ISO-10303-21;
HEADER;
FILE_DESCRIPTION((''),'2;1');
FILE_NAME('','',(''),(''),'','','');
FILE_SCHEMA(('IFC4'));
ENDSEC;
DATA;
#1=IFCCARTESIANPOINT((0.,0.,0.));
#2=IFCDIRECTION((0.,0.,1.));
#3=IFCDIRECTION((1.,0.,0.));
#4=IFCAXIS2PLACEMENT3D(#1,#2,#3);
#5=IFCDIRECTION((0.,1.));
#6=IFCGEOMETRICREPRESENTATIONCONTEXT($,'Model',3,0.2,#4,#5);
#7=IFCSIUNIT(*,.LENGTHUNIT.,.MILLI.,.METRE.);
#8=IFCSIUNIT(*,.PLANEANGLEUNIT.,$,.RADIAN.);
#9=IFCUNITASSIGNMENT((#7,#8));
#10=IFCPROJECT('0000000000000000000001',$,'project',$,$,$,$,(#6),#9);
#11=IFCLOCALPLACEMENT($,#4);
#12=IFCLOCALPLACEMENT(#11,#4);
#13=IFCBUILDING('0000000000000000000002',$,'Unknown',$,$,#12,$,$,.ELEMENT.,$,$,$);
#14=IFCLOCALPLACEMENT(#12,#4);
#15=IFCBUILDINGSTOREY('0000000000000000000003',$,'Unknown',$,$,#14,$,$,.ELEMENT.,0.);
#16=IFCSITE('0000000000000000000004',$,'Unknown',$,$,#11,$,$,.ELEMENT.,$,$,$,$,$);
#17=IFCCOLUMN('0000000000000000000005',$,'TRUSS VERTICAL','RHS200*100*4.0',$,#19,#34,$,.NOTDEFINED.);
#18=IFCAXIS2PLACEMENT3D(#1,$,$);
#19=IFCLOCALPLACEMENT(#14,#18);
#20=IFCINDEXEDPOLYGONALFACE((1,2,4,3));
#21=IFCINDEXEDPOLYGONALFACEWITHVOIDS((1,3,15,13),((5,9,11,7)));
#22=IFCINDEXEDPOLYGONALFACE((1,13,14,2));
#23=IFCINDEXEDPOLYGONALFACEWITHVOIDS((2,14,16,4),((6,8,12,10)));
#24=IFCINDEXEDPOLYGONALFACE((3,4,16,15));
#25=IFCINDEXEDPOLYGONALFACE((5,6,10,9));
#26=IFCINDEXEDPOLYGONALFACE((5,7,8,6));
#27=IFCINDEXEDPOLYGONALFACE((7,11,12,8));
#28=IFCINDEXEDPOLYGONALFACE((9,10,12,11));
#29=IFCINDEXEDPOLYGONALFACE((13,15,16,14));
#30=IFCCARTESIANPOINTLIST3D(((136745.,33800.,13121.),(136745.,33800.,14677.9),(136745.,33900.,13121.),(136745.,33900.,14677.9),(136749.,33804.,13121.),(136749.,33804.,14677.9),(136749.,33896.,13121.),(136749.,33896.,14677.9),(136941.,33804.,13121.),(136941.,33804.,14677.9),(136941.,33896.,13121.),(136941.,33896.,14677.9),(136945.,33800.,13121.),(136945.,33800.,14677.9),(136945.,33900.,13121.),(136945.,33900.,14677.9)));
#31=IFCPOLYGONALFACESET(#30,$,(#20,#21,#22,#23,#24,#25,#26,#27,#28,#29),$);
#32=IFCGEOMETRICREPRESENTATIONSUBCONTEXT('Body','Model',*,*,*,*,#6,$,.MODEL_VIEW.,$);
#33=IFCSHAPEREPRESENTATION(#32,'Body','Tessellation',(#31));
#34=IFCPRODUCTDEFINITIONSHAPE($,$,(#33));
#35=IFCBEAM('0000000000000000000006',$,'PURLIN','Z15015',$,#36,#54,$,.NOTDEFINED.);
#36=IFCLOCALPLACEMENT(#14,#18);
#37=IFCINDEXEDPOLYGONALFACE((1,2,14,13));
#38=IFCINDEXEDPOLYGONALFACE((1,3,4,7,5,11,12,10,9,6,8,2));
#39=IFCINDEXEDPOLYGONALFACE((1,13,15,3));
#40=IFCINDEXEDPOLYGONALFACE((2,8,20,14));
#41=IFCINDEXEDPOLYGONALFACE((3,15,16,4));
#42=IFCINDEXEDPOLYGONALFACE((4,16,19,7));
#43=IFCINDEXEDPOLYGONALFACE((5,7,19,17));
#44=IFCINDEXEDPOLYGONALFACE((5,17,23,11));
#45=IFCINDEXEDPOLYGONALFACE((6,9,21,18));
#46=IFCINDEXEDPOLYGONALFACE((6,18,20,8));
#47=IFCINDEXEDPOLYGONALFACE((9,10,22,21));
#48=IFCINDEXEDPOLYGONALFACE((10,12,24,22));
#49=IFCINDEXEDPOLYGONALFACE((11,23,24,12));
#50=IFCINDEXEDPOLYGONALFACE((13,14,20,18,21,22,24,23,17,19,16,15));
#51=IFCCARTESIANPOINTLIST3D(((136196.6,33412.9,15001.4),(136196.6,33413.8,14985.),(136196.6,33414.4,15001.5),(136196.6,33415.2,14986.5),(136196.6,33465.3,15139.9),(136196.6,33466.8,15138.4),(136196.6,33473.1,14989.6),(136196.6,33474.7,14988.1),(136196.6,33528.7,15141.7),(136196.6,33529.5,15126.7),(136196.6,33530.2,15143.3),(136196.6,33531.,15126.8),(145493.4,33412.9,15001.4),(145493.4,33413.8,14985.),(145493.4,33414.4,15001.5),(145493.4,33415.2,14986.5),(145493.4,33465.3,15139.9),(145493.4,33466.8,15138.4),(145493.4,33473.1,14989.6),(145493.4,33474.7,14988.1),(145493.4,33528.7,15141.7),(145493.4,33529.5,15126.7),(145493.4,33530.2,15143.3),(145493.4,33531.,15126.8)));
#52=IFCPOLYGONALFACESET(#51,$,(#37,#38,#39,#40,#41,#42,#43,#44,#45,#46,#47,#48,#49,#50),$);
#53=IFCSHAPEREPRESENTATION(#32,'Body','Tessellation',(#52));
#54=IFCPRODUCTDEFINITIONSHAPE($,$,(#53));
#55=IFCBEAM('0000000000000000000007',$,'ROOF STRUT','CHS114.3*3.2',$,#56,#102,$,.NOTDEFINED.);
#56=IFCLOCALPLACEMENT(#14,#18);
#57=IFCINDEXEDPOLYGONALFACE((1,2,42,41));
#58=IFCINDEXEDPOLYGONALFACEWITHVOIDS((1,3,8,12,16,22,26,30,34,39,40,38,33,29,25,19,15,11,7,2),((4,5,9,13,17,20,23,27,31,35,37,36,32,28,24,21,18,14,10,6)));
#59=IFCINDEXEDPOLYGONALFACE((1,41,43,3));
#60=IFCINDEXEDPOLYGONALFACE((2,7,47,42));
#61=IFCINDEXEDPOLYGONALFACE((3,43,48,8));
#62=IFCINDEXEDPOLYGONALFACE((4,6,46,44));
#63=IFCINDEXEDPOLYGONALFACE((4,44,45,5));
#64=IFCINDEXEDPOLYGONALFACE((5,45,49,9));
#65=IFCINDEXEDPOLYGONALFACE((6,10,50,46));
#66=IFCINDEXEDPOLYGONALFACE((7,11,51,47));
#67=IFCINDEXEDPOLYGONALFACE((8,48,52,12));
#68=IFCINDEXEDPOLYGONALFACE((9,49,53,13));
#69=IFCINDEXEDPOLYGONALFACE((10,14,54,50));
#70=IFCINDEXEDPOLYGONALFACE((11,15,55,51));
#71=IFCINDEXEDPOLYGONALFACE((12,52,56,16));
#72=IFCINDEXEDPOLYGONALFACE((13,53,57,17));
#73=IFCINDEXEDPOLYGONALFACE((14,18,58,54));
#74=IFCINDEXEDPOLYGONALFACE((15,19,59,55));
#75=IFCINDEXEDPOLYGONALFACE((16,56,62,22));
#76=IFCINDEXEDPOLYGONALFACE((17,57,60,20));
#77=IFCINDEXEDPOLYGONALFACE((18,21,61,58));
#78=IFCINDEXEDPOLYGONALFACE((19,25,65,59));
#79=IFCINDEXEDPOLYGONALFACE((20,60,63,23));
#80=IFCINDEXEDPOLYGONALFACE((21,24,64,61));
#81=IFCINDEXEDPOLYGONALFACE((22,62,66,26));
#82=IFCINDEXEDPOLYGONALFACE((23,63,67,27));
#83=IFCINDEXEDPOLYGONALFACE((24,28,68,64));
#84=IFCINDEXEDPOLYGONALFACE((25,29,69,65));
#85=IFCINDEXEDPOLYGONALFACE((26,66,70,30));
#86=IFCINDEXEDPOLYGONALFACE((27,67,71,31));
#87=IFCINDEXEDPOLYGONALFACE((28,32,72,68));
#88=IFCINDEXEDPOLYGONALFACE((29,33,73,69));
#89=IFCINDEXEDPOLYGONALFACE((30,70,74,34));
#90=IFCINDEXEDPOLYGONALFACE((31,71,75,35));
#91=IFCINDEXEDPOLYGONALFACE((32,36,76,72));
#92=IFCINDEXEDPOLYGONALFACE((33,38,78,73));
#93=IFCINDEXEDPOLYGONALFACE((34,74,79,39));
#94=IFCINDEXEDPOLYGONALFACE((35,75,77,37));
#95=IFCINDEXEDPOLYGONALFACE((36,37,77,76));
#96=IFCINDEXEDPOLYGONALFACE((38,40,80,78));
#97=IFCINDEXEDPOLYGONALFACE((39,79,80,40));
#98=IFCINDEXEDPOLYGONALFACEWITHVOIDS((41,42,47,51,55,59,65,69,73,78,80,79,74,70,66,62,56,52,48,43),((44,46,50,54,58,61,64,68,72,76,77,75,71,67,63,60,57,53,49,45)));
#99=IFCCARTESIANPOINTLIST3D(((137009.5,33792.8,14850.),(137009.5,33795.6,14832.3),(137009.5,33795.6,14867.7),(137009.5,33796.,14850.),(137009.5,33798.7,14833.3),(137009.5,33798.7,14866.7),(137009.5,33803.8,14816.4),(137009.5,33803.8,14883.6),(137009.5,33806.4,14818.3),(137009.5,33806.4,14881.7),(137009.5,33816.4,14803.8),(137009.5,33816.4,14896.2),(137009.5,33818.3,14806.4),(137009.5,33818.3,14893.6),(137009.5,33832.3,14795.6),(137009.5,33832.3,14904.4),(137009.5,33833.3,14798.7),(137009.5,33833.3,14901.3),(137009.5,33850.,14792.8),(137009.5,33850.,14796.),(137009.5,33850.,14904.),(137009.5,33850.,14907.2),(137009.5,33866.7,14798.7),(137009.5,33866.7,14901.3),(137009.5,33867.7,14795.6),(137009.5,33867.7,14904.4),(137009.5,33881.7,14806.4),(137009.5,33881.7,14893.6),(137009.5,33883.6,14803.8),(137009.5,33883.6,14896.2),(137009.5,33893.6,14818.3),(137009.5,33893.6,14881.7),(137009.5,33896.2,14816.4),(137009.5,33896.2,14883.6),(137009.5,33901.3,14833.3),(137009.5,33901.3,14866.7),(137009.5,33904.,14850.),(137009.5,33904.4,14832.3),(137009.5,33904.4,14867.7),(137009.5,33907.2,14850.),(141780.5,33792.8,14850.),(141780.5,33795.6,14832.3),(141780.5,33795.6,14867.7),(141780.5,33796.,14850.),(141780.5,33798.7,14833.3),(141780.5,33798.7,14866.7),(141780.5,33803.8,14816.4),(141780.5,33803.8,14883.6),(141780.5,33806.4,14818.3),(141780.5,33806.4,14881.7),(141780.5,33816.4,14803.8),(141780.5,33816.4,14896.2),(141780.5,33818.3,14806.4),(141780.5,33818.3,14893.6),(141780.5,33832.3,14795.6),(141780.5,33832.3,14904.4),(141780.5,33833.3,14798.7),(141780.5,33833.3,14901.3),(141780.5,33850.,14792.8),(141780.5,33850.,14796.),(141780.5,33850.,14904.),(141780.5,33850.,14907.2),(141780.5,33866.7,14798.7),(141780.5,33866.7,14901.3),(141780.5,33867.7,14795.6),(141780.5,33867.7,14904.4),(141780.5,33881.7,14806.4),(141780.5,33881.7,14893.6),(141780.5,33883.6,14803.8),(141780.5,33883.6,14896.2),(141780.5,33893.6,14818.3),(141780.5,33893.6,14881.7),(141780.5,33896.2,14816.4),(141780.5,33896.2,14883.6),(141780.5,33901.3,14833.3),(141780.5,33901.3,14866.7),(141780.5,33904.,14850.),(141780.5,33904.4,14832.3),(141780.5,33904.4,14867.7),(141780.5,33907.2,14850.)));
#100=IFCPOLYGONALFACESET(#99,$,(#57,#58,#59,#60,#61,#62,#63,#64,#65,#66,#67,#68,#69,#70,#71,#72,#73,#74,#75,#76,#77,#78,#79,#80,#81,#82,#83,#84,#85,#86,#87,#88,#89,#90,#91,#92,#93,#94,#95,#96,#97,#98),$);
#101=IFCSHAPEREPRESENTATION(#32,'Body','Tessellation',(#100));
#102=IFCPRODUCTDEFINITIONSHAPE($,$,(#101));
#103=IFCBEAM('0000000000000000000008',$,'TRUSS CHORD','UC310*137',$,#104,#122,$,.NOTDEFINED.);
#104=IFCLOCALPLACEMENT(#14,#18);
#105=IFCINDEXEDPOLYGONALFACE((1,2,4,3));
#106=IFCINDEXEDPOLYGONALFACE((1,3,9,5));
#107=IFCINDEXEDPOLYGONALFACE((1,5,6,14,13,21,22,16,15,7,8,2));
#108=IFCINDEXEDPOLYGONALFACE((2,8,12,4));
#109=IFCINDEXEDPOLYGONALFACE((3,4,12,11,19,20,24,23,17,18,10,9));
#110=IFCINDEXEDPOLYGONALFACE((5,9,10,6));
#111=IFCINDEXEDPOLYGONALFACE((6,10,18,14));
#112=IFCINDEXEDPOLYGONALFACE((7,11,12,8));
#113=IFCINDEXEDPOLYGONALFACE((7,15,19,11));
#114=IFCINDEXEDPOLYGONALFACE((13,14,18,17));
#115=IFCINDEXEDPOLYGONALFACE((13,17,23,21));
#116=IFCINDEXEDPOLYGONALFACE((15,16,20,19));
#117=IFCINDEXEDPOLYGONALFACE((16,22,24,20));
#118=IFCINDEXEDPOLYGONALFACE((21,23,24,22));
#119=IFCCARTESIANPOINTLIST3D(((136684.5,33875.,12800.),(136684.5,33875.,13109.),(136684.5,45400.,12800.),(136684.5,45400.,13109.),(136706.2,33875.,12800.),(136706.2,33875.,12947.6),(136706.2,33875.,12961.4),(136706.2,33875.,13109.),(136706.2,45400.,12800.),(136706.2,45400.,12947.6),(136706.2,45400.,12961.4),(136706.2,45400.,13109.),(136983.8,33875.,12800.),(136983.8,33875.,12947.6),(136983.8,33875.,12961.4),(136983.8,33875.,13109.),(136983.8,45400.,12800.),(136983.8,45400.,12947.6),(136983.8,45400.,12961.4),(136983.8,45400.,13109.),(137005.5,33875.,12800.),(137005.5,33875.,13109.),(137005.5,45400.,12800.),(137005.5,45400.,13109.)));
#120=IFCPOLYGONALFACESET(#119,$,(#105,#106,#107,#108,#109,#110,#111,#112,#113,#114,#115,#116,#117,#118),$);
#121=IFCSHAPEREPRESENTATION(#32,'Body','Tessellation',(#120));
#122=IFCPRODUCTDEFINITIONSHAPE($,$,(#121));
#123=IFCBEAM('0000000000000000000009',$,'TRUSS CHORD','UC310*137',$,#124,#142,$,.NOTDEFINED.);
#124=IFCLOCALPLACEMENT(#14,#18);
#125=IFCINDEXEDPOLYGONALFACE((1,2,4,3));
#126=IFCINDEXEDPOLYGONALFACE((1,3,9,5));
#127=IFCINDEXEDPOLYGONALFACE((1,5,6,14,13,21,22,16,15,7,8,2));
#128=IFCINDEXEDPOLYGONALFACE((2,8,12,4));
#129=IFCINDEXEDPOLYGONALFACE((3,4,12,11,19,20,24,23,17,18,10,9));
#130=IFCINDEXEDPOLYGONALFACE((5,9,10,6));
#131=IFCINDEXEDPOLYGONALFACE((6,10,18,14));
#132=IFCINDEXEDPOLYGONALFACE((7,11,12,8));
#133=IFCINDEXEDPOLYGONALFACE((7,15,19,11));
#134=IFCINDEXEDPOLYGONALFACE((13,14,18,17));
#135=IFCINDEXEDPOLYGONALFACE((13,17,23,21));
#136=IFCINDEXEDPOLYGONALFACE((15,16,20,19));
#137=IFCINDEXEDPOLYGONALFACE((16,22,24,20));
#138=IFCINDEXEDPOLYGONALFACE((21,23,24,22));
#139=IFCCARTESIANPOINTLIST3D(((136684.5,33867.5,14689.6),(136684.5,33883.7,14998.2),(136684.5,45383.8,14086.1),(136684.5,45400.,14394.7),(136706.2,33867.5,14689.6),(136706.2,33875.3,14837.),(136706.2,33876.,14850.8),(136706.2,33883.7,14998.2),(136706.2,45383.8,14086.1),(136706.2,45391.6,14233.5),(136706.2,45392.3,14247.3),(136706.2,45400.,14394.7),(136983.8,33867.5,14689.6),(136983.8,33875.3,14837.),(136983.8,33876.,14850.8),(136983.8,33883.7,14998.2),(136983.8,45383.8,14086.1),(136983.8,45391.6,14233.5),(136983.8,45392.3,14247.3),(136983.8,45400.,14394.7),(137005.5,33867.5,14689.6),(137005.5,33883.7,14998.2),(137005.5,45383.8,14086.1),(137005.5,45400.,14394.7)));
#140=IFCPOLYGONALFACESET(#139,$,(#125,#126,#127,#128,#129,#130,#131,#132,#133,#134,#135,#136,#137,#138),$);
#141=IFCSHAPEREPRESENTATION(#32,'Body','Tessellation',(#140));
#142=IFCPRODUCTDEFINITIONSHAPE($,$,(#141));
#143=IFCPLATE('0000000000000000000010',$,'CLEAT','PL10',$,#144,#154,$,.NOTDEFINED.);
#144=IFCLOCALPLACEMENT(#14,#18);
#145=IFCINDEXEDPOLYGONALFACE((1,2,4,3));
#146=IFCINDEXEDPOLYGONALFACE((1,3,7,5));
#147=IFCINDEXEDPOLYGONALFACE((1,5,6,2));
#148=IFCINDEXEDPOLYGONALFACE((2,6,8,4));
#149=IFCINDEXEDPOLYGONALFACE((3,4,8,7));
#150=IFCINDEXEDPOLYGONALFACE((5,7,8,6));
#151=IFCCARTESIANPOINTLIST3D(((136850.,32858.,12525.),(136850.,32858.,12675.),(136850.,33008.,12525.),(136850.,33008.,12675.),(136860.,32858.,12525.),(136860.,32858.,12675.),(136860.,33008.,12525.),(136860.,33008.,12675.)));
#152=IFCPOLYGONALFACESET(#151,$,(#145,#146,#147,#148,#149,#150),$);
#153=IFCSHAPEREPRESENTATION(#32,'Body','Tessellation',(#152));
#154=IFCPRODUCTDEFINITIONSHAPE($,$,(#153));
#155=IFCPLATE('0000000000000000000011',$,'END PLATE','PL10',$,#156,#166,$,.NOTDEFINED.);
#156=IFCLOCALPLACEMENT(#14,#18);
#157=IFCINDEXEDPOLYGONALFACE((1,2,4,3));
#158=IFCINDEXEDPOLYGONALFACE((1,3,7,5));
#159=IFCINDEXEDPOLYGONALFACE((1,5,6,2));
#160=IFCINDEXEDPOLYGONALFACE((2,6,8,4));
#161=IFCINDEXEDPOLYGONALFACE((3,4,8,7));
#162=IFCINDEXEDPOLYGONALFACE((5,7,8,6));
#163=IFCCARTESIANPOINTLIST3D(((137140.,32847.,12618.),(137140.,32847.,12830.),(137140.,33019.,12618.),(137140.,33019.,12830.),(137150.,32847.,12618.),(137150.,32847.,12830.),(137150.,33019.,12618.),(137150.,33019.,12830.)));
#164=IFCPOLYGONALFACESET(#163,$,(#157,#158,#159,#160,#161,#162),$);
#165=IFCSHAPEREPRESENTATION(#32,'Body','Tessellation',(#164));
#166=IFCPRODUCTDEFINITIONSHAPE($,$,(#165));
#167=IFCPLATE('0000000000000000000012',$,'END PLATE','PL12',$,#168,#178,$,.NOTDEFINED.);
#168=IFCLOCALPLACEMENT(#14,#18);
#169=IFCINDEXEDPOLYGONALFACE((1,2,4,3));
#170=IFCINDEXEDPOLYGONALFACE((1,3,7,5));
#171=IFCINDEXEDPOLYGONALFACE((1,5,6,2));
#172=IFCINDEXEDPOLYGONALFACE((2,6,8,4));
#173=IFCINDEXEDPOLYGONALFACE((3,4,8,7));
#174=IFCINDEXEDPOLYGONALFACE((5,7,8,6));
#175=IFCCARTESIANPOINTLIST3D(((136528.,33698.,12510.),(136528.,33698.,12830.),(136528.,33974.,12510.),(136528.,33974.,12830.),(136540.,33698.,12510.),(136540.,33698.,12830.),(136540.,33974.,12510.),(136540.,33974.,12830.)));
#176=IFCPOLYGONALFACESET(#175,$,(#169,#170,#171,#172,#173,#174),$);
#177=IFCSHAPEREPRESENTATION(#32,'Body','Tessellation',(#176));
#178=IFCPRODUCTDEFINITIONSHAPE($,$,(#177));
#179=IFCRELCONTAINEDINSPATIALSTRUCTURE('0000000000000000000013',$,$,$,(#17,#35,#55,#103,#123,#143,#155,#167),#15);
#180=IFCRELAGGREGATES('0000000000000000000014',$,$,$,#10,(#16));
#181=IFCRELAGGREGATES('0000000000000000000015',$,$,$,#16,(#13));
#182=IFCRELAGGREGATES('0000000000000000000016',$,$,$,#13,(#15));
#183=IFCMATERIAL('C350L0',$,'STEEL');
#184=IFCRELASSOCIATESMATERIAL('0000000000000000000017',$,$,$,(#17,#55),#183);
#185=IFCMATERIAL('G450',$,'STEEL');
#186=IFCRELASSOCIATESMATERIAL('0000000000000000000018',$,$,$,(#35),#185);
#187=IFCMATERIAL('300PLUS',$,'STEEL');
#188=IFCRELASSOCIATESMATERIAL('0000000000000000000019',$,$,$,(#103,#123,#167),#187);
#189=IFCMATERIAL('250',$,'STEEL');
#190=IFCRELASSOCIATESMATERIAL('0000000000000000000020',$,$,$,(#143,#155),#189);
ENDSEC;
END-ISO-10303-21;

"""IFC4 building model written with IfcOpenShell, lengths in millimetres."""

from ifc_helpers import new_model, si_unit, direction, frame, origin_with_axes, place, context, subcontext, project, spatial, line, indexed_curve, outline, extrude, material, element, save


model = new_model("IFC4")

# Units and contexts
model_context = context("Model", 3, precision=0.2, world=origin_with_axes(), true_north=direction((0.0, 1.0)))
body_context = subcontext(model_context, "Body", "Model", "MODEL_VIEW")
ifc_project = project(units=[si_unit("LENGTHUNIT", "METRE", prefix="MILLI"), si_unit("PLANEANGLEUNIT", "RADIAN")], contexts=[model_context])

# Site, building, storey
site_placement = place(None, origin_with_axes())
site = spatial("IfcSite", under=ifc_project, at=site_placement, Name="Unknown", CompositionType="ELEMENT")
building_placement = place(site_placement, origin_with_axes())
building = spatial("IfcBuilding", under=site, at=building_placement, Name="Unknown", CompositionType="ELEMENT")
storey_placement = place(building_placement, origin_with_axes())
storey = spatial("IfcBuildingStorey", under=building, at=storey_placement, Name="Unknown", CompositionType="ELEMENT", Elevation=0.0)

# Column
ifc_material_1 = material(Name="C350L0", Category="STEEL")
column_placement = place(storey_placement, frame((136845.0, 33850.0, 13121.0), z_axis=(0.0, -1.0, 0.0), x_axis=(0.0, 0.0, 1.0)))
element("IfcColumn", 1, at=column_placement, inside=storey, material=ifc_material_1, Name="TRUSS VERTICAL", Description="RHS200*100*4.0", PredefinedType="NOTDEFINED", context=body_context, shape_type="SolidModel", body=[
    extrude(outline(indexed_curve([(-50.0, -100.0), (50.0, -100.0), (50.0, 100.0), (-50.0, 100.0)], segments=[line(1, 2, 3, 4, 1)]), holes=[indexed_curve([(-46.0, -96.0), (-46.0, 96.0), (46.0, 96.0), (46.0, -96.0)], segments=[line(1, 2, 3, 4, 1)])]), frame((0.0, 0.0, 0.0), z_axis=(-1.0, 0.0, 0.0), x_axis=(0.0, 0.0, 1.0)), (0.0, 0.0, -1.0), 1556.9),
])

# Beams
ifc_material_2 = material(Name="G450", Category="STEEL")
beam_1_placement = place(storey_placement, frame((136196.6, 33470.0, 15064.0), z_axis=(0.0, -0.99863, -0.052336), x_axis=(1.0, 0.0, 0.0)))
element("IfcBeam", 2, at=beam_1_placement, inside=storey, material=ifc_material_2, Name="PURLIN", Description="Z15015", PredefinedType="NOTDEFINED", context=body_context, shape_type="SolidModel", body=[
    extrude(outline(indexed_curve([(60.2, -76.0), (60.2, -59.5), (58.8, -59.5), (58.8, -74.5), (0.8, -74.5), (0.8, 76.0), (-64.2, 76.0), (-64.2, 59.5), (-62.8, 59.5), (-62.8, 74.5), (-0.8, 74.5), (-0.8, -76.0)], segments=[line(1, 2, 3, 4, 5, 6, 7, 8, 9, 10, 11, 12, 1)])), frame((0.0, 0.0, 0.0), z_axis=(-1.0, 0.0, 0.0), x_axis=(0.0, 0.0, 1.0)), (0.0, 0.0, -1.0), 9296.8),
])
beam_2_placement = place(storey_placement, frame((137009.5, 33850.0, 14850.0), z_axis=(0.0, 0.0, 1.0), x_axis=(1.0, 0.0, 0.0)))
element("IfcBeam", 3, at=beam_2_placement, inside=storey, material=ifc_material_1, Name="ROOF STRUT", Description="CHS114.3*3.2", PredefinedType="NOTDEFINED", context=body_context, shape_type="SolidModel", body=[
    extrude(outline(indexed_curve([(57.1, 0.0), (54.4, 17.7), (46.2, 33.6), (33.6, 46.2), (17.7, 54.4), (0.0, 57.1), (-17.7, 54.4), (-33.6, 46.2), (-46.2, 33.6), (-54.4, 17.7), (-57.1, 0.0), (-54.4, -17.7), (-46.2, -33.6), (-33.6, -46.2), (-17.7, -54.4), (0.0, -57.1), (17.7, -54.4), (33.6, -46.2), (46.2, -33.6), (54.4, -17.7)], segments=[line(1, 2, 3, 4, 5, 6, 7, 8, 9, 10, 11, 12, 13, 14, 15, 16, 17, 18, 19, 20, 1)]), holes=[indexed_curve([(54.0, 0.0), (51.3, -16.7), (43.6, -31.7), (31.7, -43.6), (16.7, -51.3), (0.0, -54.0), (-16.7, -51.3), (-31.7, -43.6), (-43.6, -31.7), (-51.3, -16.7), (-54.0, 0.0), (-51.3, 16.7), (-43.6, 31.7), (-31.7, 43.6), (-16.7, 51.3), (0.0, 54.0), (16.7, 51.3), (31.7, 43.6), (43.6, 31.7), (51.3, 16.7)], segments=[line(1, 2, 3, 4, 5, 6, 7, 8, 9, 10, 11, 12, 13, 14, 15, 16, 17, 18, 19, 20, 1)])]), frame((0.0, 0.0, 0.0), z_axis=(-1.0, 0.0, 0.0), x_axis=(0.0, 0.0, 1.0)), (0.0, 0.0, -1.0), 4771.0),
])
ifc_material_3 = material(Name="300PLUS", Category="STEEL")
beam_3_placement = place(storey_placement, frame((136845.0, 33875.0, 12954.5), z_axis=(0.0, 0.0, 1.0), x_axis=(0.0, 1.0, 0.0)))
element("IfcBeam", 4, at=beam_3_placement, inside=storey, material=ifc_material_3, Name="TRUSS CHORD", Description="UC310*137", PredefinedType="NOTDEFINED", context=body_context, shape_type="SolidModel", body=[
    extrude(outline(indexed_curve([(-154.5, -160.5), (154.5, -160.5), (154.5, -138.8), (6.9, -138.8), (6.9, 138.8), (154.5, 138.8), (154.5, 160.5), (-154.5, 160.5), (-154.5, 138.8), (-6.9, 138.8), (-6.9, -138.8), (-154.5, -138.8)], segments=[line(1, 2, 3, 4, 5, 6, 7, 8, 9, 10, 11, 12, 1)])), frame((0.0, 0.0, 0.0), z_axis=(-1.0, 0.0, 0.0), x_axis=(0.0, 0.0, 1.0)), (0.0, 0.0, -1.0), 11525.0),
])
beam_4_placement = place(storey_placement, frame((136845.0, 33875.6, 14843.9), z_axis=(0.0, 0.052332, 0.99863), x_axis=(0.0, 0.99863, -0.052332)))
element("IfcBeam", 5, at=beam_4_placement, inside=storey, material=ifc_material_3, Name="TRUSS CHORD", Description="UC310*137", PredefinedType="NOTDEFINED", context=body_context, shape_type="SolidModel", body=[
    extrude(outline(indexed_curve([(-154.5, -160.5), (154.5, -160.5), (154.5, -138.8), (6.9, -138.8), (6.9, 138.8), (154.5, 138.8), (154.5, 160.5), (-154.5, 160.5), (-154.5, 138.8), (-6.9, 138.8), (-6.9, -138.8), (-154.5, -138.8)], segments=[line(1, 2, 3, 4, 5, 6, 7, 8, 9, 10, 11, 12, 1)])), frame((0.0, 0.0, 0.0), z_axis=(-1.0, 0.0, 0.0), x_axis=(0.0, 0.0, 1.0)), (0.0, 0.0, -1.0), 11532.1),
])

# Plates
ifc_material_4 = material(Name="250", Category="STEEL")
plate_1_placement = place(storey_placement, frame((136855.0, 32858.0, 12525.0), z_axis=(1.0, 0.0, 0.0), x_axis=(0.0, 1.0, 0.0)))
element("IfcPlate", 6, at=plate_1_placement, inside=storey, material=ifc_material_4, Name="CLEAT", Description="PL10", PredefinedType="NOTDEFINED", context=body_context, shape_type="SolidModel", body=[
    extrude(outline(indexed_curve([(0.0, 0.0), (150.0, 0.0), (150.0, 150.0), (0.0, 150.0)], segments=[line(1, 2, 3, 4, 1)])), frame((0.0, 0.0, 5.0), z_axis=(0.0, 0.0, 1.0), x_axis=(1.0, 0.0, 0.0)), (0.0, 0.0, -1.0), 10.0),
])
plate_2_placement = place(storey_placement, frame((137145.0, 33019.0, 12618.0), z_axis=(-1.0, 0.0, 0.0), x_axis=(0.0, -1.0, 0.0)))
element("IfcPlate", 7, at=plate_2_placement, inside=storey, material=ifc_material_4, Name="END PLATE", Description="PL10", PredefinedType="NOTDEFINED", context=body_context, shape_type="SolidModel", body=[
    extrude(outline(indexed_curve([(0.0, 0.0), (172.0, 0.0), (172.0, 212.0), (0.0, 212.0)], segments=[line(1, 2, 3, 4, 1)])), frame((0.0, 0.0, 5.0), z_axis=(0.0, 0.0, 1.0), x_axis=(1.0, 0.0, 0.0)), (0.0, 0.0, -1.0), 10.0),
])
plate_3_placement = place(storey_placement, frame((136534.0, 33974.0, 12510.0), z_axis=(-1.0, 0.0, 0.0), x_axis=(0.0, -1.0, 0.0)))
element("IfcPlate", 8, at=plate_3_placement, inside=storey, material=ifc_material_3, Name="END PLATE", Description="PL12", PredefinedType="NOTDEFINED", context=body_context, shape_type="SolidModel", body=[
    extrude(outline(indexed_curve([(0.0, 0.0), (276.0, 0.0), (276.0, 320.0), (0.0, 320.0)], segments=[line(1, 2, 3, 4, 1)])), frame((0.0, 0.0, 6.0), z_axis=(0.0, 0.0, 1.0), x_axis=(1.0, 0.0, 0.0)), (0.0, 0.0, -1.0), 12.0),
])

save(model, "model.ifc")
